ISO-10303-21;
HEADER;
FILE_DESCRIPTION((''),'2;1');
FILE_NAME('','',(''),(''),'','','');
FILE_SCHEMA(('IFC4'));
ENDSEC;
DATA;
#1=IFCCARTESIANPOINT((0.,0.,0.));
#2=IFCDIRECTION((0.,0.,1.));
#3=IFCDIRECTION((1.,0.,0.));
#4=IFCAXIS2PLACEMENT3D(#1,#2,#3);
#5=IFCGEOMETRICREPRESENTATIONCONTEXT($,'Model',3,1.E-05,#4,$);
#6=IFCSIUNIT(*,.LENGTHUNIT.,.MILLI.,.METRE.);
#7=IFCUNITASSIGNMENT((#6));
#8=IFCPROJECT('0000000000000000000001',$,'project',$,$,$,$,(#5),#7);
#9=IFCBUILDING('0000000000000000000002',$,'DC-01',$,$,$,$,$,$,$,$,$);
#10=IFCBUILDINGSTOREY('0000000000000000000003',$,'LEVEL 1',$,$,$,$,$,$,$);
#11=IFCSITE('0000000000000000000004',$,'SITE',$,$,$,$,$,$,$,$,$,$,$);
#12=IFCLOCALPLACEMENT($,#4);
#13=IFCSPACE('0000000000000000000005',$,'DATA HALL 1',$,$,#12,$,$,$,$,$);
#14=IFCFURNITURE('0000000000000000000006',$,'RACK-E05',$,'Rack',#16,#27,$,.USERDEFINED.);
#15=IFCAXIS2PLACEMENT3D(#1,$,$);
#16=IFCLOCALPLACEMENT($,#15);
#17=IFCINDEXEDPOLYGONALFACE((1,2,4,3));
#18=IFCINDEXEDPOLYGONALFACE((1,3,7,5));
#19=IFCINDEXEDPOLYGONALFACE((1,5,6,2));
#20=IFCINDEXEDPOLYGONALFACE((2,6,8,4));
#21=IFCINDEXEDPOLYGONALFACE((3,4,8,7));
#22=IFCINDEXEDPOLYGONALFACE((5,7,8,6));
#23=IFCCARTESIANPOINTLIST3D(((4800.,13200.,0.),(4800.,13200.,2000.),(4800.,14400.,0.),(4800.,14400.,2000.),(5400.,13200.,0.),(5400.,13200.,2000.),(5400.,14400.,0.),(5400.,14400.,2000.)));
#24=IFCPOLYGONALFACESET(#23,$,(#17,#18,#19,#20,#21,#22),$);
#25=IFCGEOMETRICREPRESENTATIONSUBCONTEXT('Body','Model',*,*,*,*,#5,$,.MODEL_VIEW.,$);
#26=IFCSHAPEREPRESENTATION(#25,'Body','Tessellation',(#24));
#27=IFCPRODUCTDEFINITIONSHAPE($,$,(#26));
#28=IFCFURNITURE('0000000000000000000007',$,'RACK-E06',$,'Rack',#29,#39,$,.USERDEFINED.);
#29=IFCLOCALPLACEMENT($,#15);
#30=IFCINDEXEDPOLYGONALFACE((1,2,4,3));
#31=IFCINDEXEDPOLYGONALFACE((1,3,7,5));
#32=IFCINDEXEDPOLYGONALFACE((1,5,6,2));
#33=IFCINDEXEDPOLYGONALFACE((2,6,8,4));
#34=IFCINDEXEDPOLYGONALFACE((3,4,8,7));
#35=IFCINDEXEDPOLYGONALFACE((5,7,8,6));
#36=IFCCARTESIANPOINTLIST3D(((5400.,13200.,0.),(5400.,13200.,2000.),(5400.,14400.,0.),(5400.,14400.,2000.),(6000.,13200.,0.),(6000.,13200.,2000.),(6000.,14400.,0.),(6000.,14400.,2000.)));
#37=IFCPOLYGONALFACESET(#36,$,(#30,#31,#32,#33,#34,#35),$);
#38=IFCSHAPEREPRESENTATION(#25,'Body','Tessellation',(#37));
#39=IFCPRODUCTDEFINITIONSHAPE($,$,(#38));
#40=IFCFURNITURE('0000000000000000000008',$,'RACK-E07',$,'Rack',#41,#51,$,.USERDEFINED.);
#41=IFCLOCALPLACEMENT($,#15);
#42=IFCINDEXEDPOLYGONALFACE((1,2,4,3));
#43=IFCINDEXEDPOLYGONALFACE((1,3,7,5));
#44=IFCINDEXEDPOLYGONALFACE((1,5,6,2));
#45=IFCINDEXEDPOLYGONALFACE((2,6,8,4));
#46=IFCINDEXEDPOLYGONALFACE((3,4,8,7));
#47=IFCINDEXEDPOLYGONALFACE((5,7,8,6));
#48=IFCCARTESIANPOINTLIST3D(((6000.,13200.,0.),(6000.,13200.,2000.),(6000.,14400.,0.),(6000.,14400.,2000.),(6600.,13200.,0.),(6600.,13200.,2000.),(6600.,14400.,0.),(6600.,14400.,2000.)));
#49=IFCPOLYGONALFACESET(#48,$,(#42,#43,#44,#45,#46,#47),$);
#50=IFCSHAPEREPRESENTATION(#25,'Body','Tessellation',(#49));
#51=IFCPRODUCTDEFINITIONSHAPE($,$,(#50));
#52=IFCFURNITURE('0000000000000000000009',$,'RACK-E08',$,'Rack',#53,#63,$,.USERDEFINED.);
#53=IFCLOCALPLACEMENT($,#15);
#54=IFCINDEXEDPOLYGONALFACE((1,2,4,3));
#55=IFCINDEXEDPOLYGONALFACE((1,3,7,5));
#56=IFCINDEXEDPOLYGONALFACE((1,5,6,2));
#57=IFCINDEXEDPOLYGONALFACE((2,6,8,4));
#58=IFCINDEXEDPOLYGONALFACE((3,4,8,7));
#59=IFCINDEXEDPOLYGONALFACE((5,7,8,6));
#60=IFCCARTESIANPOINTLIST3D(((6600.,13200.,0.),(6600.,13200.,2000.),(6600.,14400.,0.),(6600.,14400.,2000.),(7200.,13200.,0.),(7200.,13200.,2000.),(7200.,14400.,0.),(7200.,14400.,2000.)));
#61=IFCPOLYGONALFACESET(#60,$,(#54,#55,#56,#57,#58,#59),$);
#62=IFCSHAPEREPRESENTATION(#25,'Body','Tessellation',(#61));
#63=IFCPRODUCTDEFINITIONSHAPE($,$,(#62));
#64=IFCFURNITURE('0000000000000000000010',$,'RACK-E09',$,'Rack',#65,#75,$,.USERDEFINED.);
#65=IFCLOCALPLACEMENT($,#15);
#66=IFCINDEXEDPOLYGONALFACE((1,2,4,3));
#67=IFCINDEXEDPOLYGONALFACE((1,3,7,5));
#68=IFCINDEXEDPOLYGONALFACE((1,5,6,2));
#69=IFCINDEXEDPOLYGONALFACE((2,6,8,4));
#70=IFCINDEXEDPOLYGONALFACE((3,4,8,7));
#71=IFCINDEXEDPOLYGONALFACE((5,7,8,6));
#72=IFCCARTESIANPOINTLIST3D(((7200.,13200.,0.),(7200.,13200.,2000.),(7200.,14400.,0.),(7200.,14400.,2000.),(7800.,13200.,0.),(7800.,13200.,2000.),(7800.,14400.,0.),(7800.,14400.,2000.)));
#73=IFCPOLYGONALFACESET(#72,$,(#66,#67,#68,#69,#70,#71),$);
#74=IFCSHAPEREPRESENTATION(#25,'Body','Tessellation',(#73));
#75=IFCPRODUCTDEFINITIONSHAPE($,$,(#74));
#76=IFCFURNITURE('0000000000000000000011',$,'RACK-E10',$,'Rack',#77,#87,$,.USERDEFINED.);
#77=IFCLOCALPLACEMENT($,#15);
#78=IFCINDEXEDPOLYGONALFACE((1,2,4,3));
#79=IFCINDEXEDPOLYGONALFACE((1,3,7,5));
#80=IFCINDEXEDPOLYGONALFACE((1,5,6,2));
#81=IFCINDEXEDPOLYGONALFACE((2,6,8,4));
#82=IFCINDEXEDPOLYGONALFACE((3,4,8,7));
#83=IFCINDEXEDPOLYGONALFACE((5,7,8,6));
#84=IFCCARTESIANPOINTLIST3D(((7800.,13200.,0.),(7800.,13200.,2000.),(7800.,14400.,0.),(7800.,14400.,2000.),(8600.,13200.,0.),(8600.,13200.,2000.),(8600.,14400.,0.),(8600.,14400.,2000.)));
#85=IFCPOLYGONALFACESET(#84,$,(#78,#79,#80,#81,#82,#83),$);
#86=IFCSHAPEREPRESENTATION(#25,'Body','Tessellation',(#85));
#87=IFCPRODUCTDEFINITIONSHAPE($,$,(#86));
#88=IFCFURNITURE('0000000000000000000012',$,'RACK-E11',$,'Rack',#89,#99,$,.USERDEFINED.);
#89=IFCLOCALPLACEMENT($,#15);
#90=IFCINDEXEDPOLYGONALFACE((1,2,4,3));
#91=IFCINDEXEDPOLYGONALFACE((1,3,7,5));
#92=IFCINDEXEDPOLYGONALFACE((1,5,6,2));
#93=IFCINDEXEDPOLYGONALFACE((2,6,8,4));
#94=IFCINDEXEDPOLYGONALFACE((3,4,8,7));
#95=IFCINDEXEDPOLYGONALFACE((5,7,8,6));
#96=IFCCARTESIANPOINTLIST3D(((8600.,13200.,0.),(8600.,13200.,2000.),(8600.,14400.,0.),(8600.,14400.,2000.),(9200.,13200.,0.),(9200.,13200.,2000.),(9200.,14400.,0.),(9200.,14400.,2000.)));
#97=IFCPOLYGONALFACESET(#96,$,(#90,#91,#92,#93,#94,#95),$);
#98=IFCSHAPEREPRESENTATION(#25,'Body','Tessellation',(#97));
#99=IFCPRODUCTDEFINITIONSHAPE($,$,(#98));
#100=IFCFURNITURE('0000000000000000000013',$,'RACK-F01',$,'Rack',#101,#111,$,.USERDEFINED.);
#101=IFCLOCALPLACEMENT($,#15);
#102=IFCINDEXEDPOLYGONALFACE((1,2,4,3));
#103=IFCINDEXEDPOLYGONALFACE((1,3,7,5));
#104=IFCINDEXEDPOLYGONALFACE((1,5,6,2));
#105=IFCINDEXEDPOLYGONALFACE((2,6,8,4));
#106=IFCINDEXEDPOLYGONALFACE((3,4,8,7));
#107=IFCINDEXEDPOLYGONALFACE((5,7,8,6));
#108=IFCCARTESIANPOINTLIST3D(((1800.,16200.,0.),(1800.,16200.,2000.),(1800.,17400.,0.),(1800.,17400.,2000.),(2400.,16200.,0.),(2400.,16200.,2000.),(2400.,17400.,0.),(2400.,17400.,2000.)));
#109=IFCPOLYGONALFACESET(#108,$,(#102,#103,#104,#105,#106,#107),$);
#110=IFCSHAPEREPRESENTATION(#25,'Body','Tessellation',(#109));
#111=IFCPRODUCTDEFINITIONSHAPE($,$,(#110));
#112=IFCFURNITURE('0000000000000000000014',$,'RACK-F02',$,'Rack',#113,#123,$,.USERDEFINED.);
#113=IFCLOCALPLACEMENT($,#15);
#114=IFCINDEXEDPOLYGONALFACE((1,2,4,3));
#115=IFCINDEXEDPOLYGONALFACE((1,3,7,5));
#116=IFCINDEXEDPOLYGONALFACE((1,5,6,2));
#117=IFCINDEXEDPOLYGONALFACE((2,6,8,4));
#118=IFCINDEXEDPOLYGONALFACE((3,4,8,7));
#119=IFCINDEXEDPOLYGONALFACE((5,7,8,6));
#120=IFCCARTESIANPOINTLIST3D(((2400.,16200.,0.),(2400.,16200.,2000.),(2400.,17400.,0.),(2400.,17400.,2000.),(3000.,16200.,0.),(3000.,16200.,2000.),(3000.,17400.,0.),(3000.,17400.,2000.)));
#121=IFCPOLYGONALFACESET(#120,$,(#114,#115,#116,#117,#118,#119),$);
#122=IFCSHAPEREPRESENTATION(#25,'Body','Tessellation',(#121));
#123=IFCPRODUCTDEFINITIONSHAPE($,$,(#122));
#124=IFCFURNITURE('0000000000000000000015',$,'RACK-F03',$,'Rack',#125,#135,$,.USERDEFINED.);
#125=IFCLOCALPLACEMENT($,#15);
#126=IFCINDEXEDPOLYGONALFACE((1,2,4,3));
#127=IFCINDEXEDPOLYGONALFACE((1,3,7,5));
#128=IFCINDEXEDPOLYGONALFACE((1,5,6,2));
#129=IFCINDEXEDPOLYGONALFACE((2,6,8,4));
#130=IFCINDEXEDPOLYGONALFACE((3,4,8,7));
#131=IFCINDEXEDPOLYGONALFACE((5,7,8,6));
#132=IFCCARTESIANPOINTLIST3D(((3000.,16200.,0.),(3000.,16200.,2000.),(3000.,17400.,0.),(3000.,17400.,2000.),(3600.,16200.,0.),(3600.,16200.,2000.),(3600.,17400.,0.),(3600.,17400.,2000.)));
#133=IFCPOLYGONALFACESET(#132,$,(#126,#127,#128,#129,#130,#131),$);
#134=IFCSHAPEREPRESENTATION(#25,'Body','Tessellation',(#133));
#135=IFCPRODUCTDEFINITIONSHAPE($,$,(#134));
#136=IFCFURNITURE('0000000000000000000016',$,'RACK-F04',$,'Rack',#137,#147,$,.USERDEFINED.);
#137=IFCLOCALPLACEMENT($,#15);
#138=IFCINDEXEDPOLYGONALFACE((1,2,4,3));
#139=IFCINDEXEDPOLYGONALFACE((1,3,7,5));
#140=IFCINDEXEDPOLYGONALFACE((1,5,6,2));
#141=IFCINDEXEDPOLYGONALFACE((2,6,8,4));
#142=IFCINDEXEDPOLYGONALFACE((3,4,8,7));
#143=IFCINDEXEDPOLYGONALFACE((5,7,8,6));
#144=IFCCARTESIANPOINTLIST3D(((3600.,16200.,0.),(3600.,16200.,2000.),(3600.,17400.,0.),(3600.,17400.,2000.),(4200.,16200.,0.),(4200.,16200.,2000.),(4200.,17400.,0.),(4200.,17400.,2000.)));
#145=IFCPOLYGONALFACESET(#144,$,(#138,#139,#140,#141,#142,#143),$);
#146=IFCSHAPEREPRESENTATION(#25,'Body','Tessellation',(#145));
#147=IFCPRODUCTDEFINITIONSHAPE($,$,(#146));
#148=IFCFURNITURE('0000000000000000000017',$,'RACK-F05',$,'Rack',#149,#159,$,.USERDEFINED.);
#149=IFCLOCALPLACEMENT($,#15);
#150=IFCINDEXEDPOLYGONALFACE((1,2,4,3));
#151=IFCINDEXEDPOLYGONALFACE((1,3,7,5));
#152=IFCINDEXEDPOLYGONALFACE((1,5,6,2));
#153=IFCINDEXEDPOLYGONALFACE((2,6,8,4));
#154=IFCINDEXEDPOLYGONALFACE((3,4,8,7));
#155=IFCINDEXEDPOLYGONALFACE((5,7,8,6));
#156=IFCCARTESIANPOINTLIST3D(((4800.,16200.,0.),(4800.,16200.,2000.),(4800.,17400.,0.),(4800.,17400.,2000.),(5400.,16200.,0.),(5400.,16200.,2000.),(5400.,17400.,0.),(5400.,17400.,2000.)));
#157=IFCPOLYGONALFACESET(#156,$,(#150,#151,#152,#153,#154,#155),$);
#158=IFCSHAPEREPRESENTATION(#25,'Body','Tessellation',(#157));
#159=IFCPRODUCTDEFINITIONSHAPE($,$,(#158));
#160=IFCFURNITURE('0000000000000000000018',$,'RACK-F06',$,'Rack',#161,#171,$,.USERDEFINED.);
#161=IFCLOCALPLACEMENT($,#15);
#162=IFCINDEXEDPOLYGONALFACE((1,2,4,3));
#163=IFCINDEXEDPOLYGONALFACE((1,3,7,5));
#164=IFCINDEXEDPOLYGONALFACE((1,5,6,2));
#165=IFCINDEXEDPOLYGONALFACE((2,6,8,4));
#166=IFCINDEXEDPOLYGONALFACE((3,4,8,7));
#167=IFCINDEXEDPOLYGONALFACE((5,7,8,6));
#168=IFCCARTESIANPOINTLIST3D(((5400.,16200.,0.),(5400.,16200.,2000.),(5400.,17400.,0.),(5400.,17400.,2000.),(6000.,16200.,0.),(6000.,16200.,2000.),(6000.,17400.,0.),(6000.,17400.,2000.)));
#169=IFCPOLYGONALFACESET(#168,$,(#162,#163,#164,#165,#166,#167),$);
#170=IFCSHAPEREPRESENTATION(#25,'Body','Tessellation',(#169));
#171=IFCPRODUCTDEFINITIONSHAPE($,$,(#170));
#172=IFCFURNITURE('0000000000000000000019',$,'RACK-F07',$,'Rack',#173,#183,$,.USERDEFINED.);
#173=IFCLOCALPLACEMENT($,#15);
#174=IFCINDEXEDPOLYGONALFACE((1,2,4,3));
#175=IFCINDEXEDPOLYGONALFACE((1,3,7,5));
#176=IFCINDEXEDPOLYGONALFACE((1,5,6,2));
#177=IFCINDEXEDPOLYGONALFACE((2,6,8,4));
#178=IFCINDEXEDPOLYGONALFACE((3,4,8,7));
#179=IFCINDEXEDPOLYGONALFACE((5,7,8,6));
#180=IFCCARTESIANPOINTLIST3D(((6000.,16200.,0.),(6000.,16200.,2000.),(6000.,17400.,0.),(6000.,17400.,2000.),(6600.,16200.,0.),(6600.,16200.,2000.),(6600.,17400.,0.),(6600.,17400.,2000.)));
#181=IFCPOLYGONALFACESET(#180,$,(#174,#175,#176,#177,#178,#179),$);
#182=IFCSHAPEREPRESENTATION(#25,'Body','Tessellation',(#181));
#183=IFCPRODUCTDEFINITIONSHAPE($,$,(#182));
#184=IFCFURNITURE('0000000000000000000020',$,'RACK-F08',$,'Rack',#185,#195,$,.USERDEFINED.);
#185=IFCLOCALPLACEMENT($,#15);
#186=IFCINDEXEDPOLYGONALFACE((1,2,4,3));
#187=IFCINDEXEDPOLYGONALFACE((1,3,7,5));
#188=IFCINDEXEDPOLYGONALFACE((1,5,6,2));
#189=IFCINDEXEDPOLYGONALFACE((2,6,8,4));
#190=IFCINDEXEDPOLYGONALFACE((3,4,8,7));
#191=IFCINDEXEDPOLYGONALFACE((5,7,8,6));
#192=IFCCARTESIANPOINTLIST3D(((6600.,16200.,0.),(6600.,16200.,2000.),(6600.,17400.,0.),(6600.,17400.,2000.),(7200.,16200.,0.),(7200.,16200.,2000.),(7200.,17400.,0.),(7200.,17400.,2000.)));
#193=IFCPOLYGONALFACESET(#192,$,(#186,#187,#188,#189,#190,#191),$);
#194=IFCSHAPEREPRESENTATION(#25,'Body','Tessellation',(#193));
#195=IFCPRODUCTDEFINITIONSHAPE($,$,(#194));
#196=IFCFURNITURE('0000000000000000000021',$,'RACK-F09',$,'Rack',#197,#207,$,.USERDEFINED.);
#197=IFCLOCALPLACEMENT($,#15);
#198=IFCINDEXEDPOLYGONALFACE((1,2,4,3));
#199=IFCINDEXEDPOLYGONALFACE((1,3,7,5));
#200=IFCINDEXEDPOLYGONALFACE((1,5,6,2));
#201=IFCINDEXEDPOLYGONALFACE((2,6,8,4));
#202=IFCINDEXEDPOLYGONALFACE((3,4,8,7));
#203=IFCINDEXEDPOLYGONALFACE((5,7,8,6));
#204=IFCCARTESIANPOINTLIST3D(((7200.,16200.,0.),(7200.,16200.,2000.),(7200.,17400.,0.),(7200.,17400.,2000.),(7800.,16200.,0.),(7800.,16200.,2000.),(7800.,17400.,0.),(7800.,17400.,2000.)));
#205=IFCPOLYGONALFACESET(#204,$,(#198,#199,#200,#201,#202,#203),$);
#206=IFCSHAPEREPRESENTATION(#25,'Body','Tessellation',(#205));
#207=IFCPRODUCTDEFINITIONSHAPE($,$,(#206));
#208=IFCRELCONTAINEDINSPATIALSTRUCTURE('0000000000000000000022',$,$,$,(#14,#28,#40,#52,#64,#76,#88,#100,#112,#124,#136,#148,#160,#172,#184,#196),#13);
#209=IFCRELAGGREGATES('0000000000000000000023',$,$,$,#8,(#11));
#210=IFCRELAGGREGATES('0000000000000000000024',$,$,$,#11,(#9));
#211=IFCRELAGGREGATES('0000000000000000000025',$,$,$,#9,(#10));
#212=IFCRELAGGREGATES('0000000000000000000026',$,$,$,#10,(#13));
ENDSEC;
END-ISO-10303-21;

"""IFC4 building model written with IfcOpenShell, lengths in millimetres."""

from ifc_helpers import new_model, si_unit, frame, origin, origin_with_axes, place, context, subcontext, project, spatial, polyline, outline, extrude, element, save


model = new_model("IFC4")

# Units and contexts
model_context = context("Model", 3, precision=1e-05, world=origin_with_axes())
body_context = subcontext(model_context, "Body", "Model", "MODEL_VIEW")
ifc_project = project(units=[si_unit("LENGTHUNIT", "METRE", prefix="MILLI")], contexts=[model_context])

# Site, building, storey, space
site = spatial("IfcSite", under=ifc_project, Name="SITE")
building = spatial("IfcBuilding", under=site, Name="DC-01")
storey = spatial("IfcBuildingStorey", under=building, Name="LEVEL 1")
space_placement = place(None, origin_with_axes())
space = spatial("IfcSpace", under=storey, at=space_placement, Name="DATA HALL 1")

# Furniture
for number, where, z_axis, x_axis, name in (
    (1, (5400.0, 14400.0, 0.0), (0.0, 0.0, 1.0), (-1.0, 0.0, 0.0), "RACK-E05"),
    (2, (6000.0, 14400.0, 0.0), (0.0, 0.0, 1.0), (-1.0, 0.0, 0.0), "RACK-E06"),
    (3, (6600.0, 14400.0, 0.0), (0.0, 0.0, 1.0), (-1.0, 0.0, 0.0), "RACK-E07"),
    (4, (7200.0, 14400.0, 0.0), (0.0, 0.0, 1.0), (-1.0, 0.0, 0.0), "RACK-E08"),
    (5, (7800.0, 14400.0, 0.0), (0.0, 0.0, 1.0), (-1.0, 0.0, 0.0), "RACK-E09"),
):
    element("IfcFurniture", number, at=place(space_placement, frame(where, z_axis=z_axis, x_axis=x_axis)), inside=space, Name=name, ObjectType="Rack", PredefinedType="USERDEFINED", context=body_context, shape_type="SweptSolid", body=[
        extrude(outline(polyline([(0.0, 0.0), (600.0, 0.0), (600.0, 1200.0), (0.0, 1200.0), (0.0, 0.0)])), origin(), (0.0, 0.0, 1.0), 2000.0),
    ])
furniture_placement = place(space_placement, frame((8600.0, 14400.0, 0.0), z_axis=(0.0, 0.0, 1.0), x_axis=(-1.0, 0.0, 0.0)))
element("IfcFurniture", 6, at=furniture_placement, inside=space, Name="RACK-E10", ObjectType="Rack", PredefinedType="USERDEFINED", context=body_context, shape_type="SweptSolid", body=[
    extrude(outline(polyline([(0.0, 0.0), (800.0, 0.0), (800.0, 1200.0), (0.0, 1200.0), (0.0, 0.0)])), origin(), (0.0, 0.0, 1.0), 2000.0),
])
for number, where, z_axis, x_axis, name in (
    (7, (9200.0, 14400.0, 0.0), (0.0, 0.0, 1.0), (-1.0, 0.0, 0.0), "RACK-E11"),
    (8, (1800.0, 16200.0, 0.0), (0.0, 0.0, 1.0), (1.0, 0.0, 0.0), "RACK-F01"),
    (9, (2400.0, 16200.0, 0.0), (0.0, 0.0, 1.0), (1.0, 0.0, 0.0), "RACK-F02"),
    (10, (3000.0, 16200.0, 0.0), (0.0, 0.0, 1.0), (1.0, 0.0, 0.0), "RACK-F03"),
    (11, (3600.0, 16200.0, 0.0), (0.0, 0.0, 1.0), (1.0, 0.0, 0.0), "RACK-F04"),
    (12, (4800.0, 16200.0, 0.0), (0.0, 0.0, 1.0), (1.0, 0.0, 0.0), "RACK-F05"),
    (13, (5400.0, 16200.0, 0.0), (0.0, 0.0, 1.0), (1.0, 0.0, 0.0), "RACK-F06"),
    (14, (6000.0, 16200.0, 0.0), (0.0, 0.0, 1.0), (1.0, 0.0, 0.0), "RACK-F07"),
    (15, (6600.0, 16200.0, 0.0), (0.0, 0.0, 1.0), (1.0, 0.0, 0.0), "RACK-F08"),
    (16, (7200.0, 16200.0, 0.0), (0.0, 0.0, 1.0), (1.0, 0.0, 0.0), "RACK-F09"),
):
    element("IfcFurniture", number, at=place(space_placement, frame(where, z_axis=z_axis, x_axis=x_axis)), inside=space, Name=name, ObjectType="Rack", PredefinedType="USERDEFINED", context=body_context, shape_type="SweptSolid", body=[
        extrude(outline(polyline([(0.0, 0.0), (600.0, 0.0), (600.0, 1200.0), (0.0, 1200.0), (0.0, 0.0)])), origin(), (0.0, 0.0, 1.0), 2000.0),
    ])

save(model, "model.ifc")
